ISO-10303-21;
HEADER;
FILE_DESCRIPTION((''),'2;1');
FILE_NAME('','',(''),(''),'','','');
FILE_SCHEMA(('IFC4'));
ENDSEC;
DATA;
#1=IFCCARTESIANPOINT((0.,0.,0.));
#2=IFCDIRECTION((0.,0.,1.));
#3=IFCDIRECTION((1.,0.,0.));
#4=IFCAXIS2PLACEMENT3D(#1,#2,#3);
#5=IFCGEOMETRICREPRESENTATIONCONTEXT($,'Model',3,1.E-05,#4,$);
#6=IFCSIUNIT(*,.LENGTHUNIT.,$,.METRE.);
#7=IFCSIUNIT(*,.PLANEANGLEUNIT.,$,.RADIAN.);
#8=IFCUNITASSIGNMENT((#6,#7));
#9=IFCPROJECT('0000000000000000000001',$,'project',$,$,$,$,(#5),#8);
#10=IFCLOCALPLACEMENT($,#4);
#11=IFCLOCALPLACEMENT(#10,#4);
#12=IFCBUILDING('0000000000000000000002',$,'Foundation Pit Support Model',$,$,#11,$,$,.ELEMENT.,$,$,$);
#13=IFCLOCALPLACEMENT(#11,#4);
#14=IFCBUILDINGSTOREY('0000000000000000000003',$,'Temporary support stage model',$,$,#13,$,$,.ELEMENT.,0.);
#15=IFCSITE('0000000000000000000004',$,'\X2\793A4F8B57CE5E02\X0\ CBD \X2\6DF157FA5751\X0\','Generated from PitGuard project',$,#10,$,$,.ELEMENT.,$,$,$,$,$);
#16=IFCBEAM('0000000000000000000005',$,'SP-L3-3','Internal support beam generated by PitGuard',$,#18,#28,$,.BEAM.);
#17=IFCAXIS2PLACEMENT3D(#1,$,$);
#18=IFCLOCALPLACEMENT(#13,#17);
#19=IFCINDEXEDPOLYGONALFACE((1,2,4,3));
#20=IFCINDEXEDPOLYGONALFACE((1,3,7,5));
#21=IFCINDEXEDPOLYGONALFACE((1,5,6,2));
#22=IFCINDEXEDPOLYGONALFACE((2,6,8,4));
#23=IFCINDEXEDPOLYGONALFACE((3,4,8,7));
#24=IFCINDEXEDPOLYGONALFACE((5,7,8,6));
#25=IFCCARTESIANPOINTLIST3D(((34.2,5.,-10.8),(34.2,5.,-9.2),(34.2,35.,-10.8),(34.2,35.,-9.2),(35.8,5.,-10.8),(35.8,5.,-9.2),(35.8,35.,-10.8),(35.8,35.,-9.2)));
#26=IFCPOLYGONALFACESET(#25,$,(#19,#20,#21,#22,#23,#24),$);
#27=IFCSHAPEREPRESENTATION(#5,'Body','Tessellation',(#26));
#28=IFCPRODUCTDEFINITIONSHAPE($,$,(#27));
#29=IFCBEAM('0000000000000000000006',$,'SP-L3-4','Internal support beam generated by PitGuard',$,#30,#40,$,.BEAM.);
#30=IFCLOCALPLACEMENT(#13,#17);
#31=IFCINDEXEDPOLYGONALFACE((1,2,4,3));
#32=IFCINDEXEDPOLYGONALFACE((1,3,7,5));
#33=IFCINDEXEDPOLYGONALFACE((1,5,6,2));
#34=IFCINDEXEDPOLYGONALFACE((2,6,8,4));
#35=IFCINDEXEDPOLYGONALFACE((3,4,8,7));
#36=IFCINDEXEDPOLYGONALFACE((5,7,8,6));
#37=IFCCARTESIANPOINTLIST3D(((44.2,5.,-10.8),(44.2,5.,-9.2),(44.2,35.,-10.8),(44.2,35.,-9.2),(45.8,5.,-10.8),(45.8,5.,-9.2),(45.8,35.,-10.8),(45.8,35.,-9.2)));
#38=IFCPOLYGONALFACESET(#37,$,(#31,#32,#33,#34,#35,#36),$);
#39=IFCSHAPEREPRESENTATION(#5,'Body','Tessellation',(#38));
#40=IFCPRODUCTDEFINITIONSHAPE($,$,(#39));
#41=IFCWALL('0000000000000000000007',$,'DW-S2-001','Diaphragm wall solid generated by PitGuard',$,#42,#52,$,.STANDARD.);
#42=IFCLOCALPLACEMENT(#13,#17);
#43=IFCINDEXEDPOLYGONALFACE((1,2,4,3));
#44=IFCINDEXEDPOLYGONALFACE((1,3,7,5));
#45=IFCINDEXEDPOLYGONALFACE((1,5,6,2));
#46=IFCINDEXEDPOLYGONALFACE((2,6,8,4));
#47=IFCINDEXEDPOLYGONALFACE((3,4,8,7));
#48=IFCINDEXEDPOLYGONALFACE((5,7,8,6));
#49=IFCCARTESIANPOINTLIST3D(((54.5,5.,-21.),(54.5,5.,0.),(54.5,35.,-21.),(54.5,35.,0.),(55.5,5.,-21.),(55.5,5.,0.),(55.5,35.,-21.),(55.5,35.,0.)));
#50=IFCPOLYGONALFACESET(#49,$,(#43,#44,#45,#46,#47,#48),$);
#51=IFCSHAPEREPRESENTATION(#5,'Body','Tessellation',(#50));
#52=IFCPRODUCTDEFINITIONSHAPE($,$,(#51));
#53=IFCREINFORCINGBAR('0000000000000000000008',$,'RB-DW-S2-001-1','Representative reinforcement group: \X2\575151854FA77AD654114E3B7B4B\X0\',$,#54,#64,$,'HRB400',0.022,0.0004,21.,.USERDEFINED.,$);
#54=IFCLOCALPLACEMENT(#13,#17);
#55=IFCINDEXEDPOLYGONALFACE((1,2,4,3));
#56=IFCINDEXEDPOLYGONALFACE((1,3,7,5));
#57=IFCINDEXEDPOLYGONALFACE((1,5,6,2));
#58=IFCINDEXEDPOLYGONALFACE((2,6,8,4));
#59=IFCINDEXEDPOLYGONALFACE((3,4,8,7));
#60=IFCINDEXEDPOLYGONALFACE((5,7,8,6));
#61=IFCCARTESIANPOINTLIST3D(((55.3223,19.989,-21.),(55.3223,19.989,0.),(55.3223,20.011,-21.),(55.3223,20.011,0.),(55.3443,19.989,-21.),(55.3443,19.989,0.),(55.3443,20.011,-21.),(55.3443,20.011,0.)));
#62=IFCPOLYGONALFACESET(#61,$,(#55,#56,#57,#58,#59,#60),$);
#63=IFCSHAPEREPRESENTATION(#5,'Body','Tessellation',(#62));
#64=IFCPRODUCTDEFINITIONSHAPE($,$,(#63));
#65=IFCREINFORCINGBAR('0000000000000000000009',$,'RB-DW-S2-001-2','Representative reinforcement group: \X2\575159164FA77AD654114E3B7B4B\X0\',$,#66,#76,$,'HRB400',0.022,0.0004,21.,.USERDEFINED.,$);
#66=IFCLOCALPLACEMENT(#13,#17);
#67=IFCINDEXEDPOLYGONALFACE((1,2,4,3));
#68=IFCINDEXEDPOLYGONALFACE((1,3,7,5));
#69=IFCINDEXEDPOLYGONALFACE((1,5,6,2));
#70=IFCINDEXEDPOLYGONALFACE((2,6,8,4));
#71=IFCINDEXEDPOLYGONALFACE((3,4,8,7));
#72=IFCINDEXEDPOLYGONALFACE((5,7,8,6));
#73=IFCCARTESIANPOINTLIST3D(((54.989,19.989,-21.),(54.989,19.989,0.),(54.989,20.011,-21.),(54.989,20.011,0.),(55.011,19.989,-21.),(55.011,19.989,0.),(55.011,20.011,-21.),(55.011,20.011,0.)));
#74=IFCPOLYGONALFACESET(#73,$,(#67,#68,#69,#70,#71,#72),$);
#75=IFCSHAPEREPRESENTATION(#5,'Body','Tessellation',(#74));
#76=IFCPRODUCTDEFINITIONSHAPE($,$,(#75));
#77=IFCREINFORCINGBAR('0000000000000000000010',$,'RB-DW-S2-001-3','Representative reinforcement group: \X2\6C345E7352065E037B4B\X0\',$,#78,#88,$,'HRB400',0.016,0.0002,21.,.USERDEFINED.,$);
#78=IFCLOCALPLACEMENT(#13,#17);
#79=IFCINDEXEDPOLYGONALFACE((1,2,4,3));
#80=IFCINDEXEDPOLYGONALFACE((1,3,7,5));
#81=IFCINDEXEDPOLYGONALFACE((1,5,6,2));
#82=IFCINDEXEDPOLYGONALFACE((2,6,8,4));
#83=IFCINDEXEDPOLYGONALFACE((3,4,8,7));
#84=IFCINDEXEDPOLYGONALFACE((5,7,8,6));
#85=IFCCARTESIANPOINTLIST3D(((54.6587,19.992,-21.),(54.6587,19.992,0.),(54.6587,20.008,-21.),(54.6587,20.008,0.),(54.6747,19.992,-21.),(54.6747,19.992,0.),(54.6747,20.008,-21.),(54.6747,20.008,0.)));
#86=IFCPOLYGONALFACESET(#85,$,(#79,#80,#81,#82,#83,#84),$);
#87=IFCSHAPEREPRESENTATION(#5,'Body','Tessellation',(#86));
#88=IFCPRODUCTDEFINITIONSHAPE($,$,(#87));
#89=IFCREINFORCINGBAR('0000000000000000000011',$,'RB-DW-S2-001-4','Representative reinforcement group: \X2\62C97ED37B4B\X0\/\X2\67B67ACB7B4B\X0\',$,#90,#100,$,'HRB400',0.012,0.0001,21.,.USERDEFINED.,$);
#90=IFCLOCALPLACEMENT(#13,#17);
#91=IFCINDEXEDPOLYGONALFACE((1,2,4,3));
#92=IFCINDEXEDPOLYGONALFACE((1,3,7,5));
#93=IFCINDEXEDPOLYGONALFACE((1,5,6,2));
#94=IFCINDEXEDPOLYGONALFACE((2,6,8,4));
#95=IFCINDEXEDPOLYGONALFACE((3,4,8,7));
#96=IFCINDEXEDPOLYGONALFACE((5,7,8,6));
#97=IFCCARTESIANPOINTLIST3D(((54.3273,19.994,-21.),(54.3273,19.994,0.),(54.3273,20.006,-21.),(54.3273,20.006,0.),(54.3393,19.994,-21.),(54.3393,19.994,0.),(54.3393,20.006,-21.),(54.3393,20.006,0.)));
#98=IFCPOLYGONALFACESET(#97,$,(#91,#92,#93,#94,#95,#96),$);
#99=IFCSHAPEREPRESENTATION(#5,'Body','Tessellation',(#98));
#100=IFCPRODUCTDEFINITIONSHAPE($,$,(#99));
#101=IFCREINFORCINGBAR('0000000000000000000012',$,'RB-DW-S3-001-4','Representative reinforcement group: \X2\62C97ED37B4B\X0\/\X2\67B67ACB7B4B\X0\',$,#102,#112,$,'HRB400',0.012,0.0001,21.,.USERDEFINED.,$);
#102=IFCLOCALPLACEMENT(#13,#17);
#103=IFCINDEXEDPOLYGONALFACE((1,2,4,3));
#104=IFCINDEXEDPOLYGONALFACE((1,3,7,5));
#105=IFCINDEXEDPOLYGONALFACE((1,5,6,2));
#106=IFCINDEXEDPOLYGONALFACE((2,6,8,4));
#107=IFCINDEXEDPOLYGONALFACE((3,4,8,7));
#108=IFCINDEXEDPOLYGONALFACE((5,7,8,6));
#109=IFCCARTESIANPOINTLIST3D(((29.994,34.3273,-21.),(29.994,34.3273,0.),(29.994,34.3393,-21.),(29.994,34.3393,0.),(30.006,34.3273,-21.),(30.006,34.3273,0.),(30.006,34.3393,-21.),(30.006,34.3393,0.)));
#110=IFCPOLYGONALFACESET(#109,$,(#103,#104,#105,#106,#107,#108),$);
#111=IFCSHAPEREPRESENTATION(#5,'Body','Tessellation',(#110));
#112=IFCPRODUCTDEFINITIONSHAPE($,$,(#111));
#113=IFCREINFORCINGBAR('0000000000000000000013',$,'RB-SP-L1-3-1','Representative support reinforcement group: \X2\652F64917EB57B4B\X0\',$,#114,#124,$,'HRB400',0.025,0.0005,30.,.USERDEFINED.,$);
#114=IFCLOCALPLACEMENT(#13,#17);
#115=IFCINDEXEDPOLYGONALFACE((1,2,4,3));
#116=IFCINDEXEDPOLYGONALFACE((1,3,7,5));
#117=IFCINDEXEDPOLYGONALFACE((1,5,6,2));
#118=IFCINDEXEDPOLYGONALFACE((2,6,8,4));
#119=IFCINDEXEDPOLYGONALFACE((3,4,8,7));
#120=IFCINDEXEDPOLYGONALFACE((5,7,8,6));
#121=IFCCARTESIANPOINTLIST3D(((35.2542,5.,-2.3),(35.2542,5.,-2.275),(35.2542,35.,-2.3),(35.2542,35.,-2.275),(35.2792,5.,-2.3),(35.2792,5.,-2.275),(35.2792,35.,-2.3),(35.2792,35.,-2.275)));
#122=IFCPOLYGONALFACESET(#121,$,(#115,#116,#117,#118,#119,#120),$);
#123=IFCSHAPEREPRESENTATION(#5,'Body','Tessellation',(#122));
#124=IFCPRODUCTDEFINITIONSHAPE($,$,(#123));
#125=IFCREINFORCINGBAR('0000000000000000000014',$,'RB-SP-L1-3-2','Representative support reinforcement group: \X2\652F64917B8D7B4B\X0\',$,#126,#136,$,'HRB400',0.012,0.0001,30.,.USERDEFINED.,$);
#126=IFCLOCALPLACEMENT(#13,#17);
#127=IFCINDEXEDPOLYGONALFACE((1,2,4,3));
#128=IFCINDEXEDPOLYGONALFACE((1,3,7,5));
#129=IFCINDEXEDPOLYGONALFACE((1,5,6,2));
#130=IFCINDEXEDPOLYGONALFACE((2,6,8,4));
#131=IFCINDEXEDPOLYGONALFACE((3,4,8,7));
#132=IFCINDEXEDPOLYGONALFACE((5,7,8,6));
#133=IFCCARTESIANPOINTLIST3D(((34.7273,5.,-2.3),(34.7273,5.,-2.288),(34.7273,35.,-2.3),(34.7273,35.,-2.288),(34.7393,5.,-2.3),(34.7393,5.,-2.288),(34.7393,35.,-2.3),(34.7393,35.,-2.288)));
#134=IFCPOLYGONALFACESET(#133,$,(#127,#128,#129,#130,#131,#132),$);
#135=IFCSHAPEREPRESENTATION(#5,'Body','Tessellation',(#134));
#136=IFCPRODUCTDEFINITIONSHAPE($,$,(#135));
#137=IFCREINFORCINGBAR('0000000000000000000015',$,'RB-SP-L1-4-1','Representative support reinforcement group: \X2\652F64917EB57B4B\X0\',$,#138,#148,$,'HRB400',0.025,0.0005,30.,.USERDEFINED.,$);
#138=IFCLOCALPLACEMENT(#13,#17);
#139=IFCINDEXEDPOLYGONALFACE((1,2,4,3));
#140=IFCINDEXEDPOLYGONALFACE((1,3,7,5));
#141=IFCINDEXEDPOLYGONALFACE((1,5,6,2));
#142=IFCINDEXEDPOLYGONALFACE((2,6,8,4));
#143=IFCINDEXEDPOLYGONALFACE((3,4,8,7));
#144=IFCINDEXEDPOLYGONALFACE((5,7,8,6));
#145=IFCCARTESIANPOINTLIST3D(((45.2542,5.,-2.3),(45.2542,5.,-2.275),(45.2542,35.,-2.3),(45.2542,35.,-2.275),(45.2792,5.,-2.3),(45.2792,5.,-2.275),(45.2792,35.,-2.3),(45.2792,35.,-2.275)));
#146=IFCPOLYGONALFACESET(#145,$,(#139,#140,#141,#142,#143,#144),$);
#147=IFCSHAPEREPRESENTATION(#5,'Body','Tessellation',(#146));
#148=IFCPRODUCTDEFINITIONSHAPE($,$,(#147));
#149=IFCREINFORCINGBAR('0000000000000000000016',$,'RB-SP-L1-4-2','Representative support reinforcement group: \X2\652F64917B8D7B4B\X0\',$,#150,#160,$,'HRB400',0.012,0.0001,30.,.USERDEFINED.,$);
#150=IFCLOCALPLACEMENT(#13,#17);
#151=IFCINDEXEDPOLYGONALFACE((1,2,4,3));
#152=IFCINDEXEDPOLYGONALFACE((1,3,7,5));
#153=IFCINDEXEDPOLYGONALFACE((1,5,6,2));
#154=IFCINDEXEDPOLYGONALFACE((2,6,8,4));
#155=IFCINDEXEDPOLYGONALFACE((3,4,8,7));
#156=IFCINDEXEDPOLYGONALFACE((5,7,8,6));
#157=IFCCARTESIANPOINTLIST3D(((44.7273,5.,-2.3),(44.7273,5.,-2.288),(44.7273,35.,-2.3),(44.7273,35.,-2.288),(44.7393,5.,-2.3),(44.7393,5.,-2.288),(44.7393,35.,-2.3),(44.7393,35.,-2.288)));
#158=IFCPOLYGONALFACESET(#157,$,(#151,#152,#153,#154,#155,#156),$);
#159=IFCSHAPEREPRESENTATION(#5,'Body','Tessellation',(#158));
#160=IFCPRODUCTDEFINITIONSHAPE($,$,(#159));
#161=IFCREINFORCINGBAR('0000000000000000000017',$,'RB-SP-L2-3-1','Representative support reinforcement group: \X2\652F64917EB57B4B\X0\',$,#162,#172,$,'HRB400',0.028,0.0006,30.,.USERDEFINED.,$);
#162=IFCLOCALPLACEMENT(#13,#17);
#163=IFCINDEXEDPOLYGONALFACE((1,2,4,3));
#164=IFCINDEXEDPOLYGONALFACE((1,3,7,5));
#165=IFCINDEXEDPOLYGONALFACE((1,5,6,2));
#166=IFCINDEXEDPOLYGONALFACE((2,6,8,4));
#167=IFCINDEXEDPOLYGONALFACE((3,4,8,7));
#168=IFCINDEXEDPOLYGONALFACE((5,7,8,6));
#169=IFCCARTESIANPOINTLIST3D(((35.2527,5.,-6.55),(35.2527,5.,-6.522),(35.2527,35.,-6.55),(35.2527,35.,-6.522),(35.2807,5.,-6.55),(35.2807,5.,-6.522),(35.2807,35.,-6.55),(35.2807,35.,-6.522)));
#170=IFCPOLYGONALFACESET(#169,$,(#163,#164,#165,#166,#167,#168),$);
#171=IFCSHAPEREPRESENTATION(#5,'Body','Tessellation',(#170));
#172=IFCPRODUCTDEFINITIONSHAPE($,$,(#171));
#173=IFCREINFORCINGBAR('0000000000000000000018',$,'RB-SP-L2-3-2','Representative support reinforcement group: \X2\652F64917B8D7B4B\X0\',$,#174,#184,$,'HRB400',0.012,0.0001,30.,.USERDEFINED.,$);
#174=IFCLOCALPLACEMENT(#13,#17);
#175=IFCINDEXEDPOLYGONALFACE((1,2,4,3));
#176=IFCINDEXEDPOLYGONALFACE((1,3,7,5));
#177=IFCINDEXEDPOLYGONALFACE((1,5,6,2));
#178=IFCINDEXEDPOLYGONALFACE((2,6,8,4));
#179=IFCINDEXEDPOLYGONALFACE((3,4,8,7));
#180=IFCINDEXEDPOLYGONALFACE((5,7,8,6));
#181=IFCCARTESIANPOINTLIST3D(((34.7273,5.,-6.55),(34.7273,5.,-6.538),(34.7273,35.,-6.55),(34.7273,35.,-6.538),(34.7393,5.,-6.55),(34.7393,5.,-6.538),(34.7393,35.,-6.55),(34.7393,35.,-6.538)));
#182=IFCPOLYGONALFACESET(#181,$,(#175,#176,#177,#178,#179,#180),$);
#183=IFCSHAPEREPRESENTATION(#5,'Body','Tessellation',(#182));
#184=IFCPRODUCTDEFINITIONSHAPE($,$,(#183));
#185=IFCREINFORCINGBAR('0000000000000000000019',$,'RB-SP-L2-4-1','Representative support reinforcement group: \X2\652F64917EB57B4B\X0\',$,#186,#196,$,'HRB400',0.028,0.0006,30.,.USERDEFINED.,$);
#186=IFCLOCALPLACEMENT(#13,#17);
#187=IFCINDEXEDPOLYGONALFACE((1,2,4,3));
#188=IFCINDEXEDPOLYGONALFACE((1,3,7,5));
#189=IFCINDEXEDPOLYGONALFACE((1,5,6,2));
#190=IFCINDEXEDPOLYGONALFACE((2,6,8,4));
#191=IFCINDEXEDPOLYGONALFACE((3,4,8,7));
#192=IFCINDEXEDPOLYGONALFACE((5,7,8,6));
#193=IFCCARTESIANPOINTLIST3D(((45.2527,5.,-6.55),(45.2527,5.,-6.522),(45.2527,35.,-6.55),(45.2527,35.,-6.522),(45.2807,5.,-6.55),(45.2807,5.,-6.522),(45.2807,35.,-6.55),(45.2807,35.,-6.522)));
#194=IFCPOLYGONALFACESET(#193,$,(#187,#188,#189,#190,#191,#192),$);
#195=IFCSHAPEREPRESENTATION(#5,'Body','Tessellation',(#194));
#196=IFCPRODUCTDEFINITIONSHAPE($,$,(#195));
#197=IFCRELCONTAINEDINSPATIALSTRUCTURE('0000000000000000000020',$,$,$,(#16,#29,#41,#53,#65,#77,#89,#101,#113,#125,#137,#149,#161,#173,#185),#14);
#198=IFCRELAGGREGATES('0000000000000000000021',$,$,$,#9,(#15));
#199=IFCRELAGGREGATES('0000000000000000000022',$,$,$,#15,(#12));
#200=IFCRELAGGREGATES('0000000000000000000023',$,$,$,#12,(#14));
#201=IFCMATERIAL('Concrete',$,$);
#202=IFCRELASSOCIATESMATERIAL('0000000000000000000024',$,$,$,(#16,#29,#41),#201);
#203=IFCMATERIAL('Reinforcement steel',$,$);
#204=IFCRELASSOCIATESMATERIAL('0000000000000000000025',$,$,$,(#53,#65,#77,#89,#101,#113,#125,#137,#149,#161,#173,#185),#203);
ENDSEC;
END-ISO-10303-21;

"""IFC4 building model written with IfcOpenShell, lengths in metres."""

from ifc_helpers import new_model, si_unit, frame, origin_with_axes, origin_2d, place, context, project, spatial, rectangle, extrude, material, element, save


model = new_model("IFC4")

# Units and contexts
model_context = context("Model", 3, precision=1e-05, world=origin_with_axes())
ifc_project = project(units=[si_unit("LENGTHUNIT", "METRE"), si_unit("PLANEANGLEUNIT", "RADIAN")], contexts=[model_context])

# Site, building, storey
site_placement = place(None, origin_with_axes())
site = spatial("IfcSite", under=ifc_project, at=site_placement, Name="示例城市 CBD 深基坑", Description="Generated from PitGuard project", CompositionType="ELEMENT")
building_placement = place(site_placement, origin_with_axes())
building = spatial("IfcBuilding", under=site, at=building_placement, Name="Foundation Pit Support Model", CompositionType="ELEMENT")
storey_placement = place(building_placement, origin_with_axes())
storey = spatial("IfcBuildingStorey", under=building, at=storey_placement, Name="Temporary support stage model", CompositionType="ELEMENT", Elevation=0.0)

# Beams
ifc_material_1 = material(Name="Concrete")
for number, where, z_axis, x_axis, name in (
    (1, (35.0, 20.0, -10.8), (0.0, 0.0, 1.0), (0.0, 1.0, 0.0), "SP-L3-3"),
    (2, (45.0, 20.0, -10.8), (0.0, 0.0, 1.0), (0.0, 1.0, 0.0), "SP-L3-4"),
):
    element("IfcBeam", number, at=place(storey_placement, frame(where, z_axis=z_axis, x_axis=x_axis)), inside=storey, material=ifc_material_1, Name=name, Description="Internal support beam generated by PitGuard", PredefinedType="BEAM", context=model_context, shape_type="SweptSolid", body=[
        extrude(rectangle(XDim=30.0, YDim=1.6, at=origin_2d()), origin_with_axes(), (0.0, 0.0, 1.0), 1.6),
    ])

# Wall
wall_placement = place(storey_placement, frame((55.0, 20.0, -21.0), z_axis=(0.0, 0.0, 1.0), x_axis=(0.0, 1.0, 0.0)))
element("IfcWall", 3, at=wall_placement, inside=storey, material=ifc_material_1, Name="DW-S2-001", Description="Diaphragm wall solid generated by PitGuard", PredefinedType="STANDARD", context=model_context, shape_type="SweptSolid", body=[
    extrude(rectangle(XDim=30.0, YDim=1.0, at=origin_2d()), origin_with_axes(), (0.0, 0.0, 1.0), 21.0),
])

# Reinforcing bars
ifc_material_2 = material(Name="Reinforcement steel")
for number, where, z_axis, x_axis, name, description in (
    (4, (55.3333, 20.0, -21.0), (0.0, 0.0, 1.0), (1.0, 0.0, 0.0), "RB-DW-S2-001-1", "Representative reinforcement group: 坑内侧竖向主筋"),
    (5, (55.0, 20.0, -21.0), (0.0, 0.0, 1.0), (1.0, 0.0, 0.0), "RB-DW-S2-001-2", "Representative reinforcement group: 坑外侧竖向主筋"),
):
    element("IfcReinforcingBar", number, at=place(storey_placement, frame(where, z_axis=z_axis, x_axis=x_axis)), inside=storey, material=ifc_material_2, Name=name, Description=description, SteelGrade="HRB400", BarLength=21.0, CrossSectionArea=0.0004, NominalDiameter=0.022, PredefinedType="USERDEFINED", context=model_context, shape_type="SweptSolid", body=[
        extrude(rectangle(XDim=0.022, YDim=0.022, at=origin_2d()), origin_with_axes(), (0.0, 0.0, 1.0), 21.0),
    ])
reinforcing_bar_1_placement = place(storey_placement, frame((54.6667, 20.0, -21.0), z_axis=(0.0, 0.0, 1.0), x_axis=(1.0, 0.0, 0.0)))
element("IfcReinforcingBar", 6, at=reinforcing_bar_1_placement, inside=storey, material=ifc_material_2, Name="RB-DW-S2-001-3", Description="Representative reinforcement group: 水平分布筋", SteelGrade="HRB400", BarLength=21.0, CrossSectionArea=0.0002, NominalDiameter=0.016, PredefinedType="USERDEFINED", context=model_context, shape_type="SweptSolid", body=[
    extrude(rectangle(XDim=0.016, YDim=0.016, at=origin_2d()), origin_with_axes(), (0.0, 0.0, 1.0), 21.0),
])
for number, where, z_axis, x_axis, name in (
    (7, (54.3333, 20.0, -21.0), (0.0, 0.0, 1.0), (1.0, 0.0, 0.0), "RB-DW-S2-001-4"),
    (8, (30.0, 34.3333, -21.0), (0.0, 0.0, 1.0), (1.0, 0.0, 0.0), "RB-DW-S3-001-4"),
):
    element("IfcReinforcingBar", number, at=place(storey_placement, frame(where, z_axis=z_axis, x_axis=x_axis)), inside=storey, material=ifc_material_2, Name=name, Description="Representative reinforcement group: 拉结筋/架立筋", SteelGrade="HRB400", BarLength=21.0, CrossSectionArea=0.0001, NominalDiameter=0.012, PredefinedType="USERDEFINED", context=model_context, shape_type="SweptSolid", body=[
        extrude(rectangle(XDim=0.012, YDim=0.012, at=origin_2d()), origin_with_axes(), (0.0, 0.0, 1.0), 21.0),
    ])
reinforcing_bar_2_placement = place(storey_placement, frame((35.2667, 20.0, -2.3), z_axis=(0.0, 0.0, 1.0), x_axis=(0.0, 1.0, 0.0)))
element("IfcReinforcingBar", 9, at=reinforcing_bar_2_placement, inside=storey, material=ifc_material_2, Name="RB-SP-L1-3-1", Description="Representative support reinforcement group: 支撑纵筋", SteelGrade="HRB400", BarLength=30.0, CrossSectionArea=0.0005, NominalDiameter=0.025, PredefinedType="USERDEFINED", context=model_context, shape_type="SweptSolid", body=[
    extrude(rectangle(XDim=30.0, YDim=0.025, at=origin_2d()), origin_with_axes(), (0.0, 0.0, 1.0), 0.025),
])
reinforcing_bar_3_placement = place(storey_placement, frame((34.7333, 20.0, -2.3), z_axis=(0.0, 0.0, 1.0), x_axis=(0.0, 1.0, 0.0)))
element("IfcReinforcingBar", 10, at=reinforcing_bar_3_placement, inside=storey, material=ifc_material_2, Name="RB-SP-L1-3-2", Description="Representative support reinforcement group: 支撑箍筋", SteelGrade="HRB400", BarLength=30.0, CrossSectionArea=0.0001, NominalDiameter=0.012, PredefinedType="USERDEFINED", context=model_context, shape_type="SweptSolid", body=[
    extrude(rectangle(XDim=30.0, YDim=0.012, at=origin_2d()), origin_with_axes(), (0.0, 0.0, 1.0), 0.012),
])
reinforcing_bar_4_placement = place(storey_placement, frame((45.2667, 20.0, -2.3), z_axis=(0.0, 0.0, 1.0), x_axis=(0.0, 1.0, 0.0)))
element("IfcReinforcingBar", 11, at=reinforcing_bar_4_placement, inside=storey, material=ifc_material_2, Name="RB-SP-L1-4-1", Description="Representative support reinforcement group: 支撑纵筋", SteelGrade="HRB400", BarLength=30.0, CrossSectionArea=0.0005, NominalDiameter=0.025, PredefinedType="USERDEFINED", context=model_context, shape_type="SweptSolid", body=[
    extrude(rectangle(XDim=30.0, YDim=0.025, at=origin_2d()), origin_with_axes(), (0.0, 0.0, 1.0), 0.025),
])
reinforcing_bar_5_placement = place(storey_placement, frame((44.7333, 20.0, -2.3), z_axis=(0.0, 0.0, 1.0), x_axis=(0.0, 1.0, 0.0)))
element("IfcReinforcingBar", 12, at=reinforcing_bar_5_placement, inside=storey, material=ifc_material_2, Name="RB-SP-L1-4-2", Description="Representative support reinforcement group: 支撑箍筋", SteelGrade="HRB400", BarLength=30.0, CrossSectionArea=0.0001, NominalDiameter=0.012, PredefinedType="USERDEFINED", context=model_context, shape_type="SweptSolid", body=[
    extrude(rectangle(XDim=30.0, YDim=0.012, at=origin_2d()), origin_with_axes(), (0.0, 0.0, 1.0), 0.012),
])
reinforcing_bar_6_placement = place(storey_placement, frame((35.2667, 20.0, -6.55), z_axis=(0.0, 0.0, 1.0), x_axis=(0.0, 1.0, 0.0)))
element("IfcReinforcingBar", 13, at=reinforcing_bar_6_placement, inside=storey, material=ifc_material_2, Name="RB-SP-L2-3-1", Description="Representative support reinforcement group: 支撑纵筋", SteelGrade="HRB400", BarLength=30.0, CrossSectionArea=0.0006, NominalDiameter=0.028, PredefinedType="USERDEFINED", context=model_context, shape_type="SweptSolid", body=[
    extrude(rectangle(XDim=30.0, YDim=0.028, at=origin_2d()), origin_with_axes(), (0.0, 0.0, 1.0), 0.028),
])
reinforcing_bar_7_placement = place(storey_placement, frame((34.7333, 20.0, -6.55), z_axis=(0.0, 0.0, 1.0), x_axis=(0.0, 1.0, 0.0)))
element("IfcReinforcingBar", 14, at=reinforcing_bar_7_placement, inside=storey, material=ifc_material_2, Name="RB-SP-L2-3-2", Description="Representative support reinforcement group: 支撑箍筋", SteelGrade="HRB400", BarLength=30.0, CrossSectionArea=0.0001, NominalDiameter=0.012, PredefinedType="USERDEFINED", context=model_context, shape_type="SweptSolid", body=[
    extrude(rectangle(XDim=30.0, YDim=0.012, at=origin_2d()), origin_with_axes(), (0.0, 0.0, 1.0), 0.012),
])
reinforcing_bar_8_placement = place(storey_placement, frame((45.2667, 20.0, -6.55), z_axis=(0.0, 0.0, 1.0), x_axis=(0.0, 1.0, 0.0)))
element("IfcReinforcingBar", 15, at=reinforcing_bar_8_placement, inside=storey, material=ifc_material_2, Name="RB-SP-L2-4-1", Description="Representative support reinforcement group: 支撑纵筋", SteelGrade="HRB400", BarLength=30.0, CrossSectionArea=0.0006, NominalDiameter=0.028, PredefinedType="USERDEFINED", context=model_context, shape_type="SweptSolid", body=[
    extrude(rectangle(XDim=30.0, YDim=0.028, at=origin_2d()), origin_with_axes(), (0.0, 0.0, 1.0), 0.028),
])

save(model, "model.ifc")
